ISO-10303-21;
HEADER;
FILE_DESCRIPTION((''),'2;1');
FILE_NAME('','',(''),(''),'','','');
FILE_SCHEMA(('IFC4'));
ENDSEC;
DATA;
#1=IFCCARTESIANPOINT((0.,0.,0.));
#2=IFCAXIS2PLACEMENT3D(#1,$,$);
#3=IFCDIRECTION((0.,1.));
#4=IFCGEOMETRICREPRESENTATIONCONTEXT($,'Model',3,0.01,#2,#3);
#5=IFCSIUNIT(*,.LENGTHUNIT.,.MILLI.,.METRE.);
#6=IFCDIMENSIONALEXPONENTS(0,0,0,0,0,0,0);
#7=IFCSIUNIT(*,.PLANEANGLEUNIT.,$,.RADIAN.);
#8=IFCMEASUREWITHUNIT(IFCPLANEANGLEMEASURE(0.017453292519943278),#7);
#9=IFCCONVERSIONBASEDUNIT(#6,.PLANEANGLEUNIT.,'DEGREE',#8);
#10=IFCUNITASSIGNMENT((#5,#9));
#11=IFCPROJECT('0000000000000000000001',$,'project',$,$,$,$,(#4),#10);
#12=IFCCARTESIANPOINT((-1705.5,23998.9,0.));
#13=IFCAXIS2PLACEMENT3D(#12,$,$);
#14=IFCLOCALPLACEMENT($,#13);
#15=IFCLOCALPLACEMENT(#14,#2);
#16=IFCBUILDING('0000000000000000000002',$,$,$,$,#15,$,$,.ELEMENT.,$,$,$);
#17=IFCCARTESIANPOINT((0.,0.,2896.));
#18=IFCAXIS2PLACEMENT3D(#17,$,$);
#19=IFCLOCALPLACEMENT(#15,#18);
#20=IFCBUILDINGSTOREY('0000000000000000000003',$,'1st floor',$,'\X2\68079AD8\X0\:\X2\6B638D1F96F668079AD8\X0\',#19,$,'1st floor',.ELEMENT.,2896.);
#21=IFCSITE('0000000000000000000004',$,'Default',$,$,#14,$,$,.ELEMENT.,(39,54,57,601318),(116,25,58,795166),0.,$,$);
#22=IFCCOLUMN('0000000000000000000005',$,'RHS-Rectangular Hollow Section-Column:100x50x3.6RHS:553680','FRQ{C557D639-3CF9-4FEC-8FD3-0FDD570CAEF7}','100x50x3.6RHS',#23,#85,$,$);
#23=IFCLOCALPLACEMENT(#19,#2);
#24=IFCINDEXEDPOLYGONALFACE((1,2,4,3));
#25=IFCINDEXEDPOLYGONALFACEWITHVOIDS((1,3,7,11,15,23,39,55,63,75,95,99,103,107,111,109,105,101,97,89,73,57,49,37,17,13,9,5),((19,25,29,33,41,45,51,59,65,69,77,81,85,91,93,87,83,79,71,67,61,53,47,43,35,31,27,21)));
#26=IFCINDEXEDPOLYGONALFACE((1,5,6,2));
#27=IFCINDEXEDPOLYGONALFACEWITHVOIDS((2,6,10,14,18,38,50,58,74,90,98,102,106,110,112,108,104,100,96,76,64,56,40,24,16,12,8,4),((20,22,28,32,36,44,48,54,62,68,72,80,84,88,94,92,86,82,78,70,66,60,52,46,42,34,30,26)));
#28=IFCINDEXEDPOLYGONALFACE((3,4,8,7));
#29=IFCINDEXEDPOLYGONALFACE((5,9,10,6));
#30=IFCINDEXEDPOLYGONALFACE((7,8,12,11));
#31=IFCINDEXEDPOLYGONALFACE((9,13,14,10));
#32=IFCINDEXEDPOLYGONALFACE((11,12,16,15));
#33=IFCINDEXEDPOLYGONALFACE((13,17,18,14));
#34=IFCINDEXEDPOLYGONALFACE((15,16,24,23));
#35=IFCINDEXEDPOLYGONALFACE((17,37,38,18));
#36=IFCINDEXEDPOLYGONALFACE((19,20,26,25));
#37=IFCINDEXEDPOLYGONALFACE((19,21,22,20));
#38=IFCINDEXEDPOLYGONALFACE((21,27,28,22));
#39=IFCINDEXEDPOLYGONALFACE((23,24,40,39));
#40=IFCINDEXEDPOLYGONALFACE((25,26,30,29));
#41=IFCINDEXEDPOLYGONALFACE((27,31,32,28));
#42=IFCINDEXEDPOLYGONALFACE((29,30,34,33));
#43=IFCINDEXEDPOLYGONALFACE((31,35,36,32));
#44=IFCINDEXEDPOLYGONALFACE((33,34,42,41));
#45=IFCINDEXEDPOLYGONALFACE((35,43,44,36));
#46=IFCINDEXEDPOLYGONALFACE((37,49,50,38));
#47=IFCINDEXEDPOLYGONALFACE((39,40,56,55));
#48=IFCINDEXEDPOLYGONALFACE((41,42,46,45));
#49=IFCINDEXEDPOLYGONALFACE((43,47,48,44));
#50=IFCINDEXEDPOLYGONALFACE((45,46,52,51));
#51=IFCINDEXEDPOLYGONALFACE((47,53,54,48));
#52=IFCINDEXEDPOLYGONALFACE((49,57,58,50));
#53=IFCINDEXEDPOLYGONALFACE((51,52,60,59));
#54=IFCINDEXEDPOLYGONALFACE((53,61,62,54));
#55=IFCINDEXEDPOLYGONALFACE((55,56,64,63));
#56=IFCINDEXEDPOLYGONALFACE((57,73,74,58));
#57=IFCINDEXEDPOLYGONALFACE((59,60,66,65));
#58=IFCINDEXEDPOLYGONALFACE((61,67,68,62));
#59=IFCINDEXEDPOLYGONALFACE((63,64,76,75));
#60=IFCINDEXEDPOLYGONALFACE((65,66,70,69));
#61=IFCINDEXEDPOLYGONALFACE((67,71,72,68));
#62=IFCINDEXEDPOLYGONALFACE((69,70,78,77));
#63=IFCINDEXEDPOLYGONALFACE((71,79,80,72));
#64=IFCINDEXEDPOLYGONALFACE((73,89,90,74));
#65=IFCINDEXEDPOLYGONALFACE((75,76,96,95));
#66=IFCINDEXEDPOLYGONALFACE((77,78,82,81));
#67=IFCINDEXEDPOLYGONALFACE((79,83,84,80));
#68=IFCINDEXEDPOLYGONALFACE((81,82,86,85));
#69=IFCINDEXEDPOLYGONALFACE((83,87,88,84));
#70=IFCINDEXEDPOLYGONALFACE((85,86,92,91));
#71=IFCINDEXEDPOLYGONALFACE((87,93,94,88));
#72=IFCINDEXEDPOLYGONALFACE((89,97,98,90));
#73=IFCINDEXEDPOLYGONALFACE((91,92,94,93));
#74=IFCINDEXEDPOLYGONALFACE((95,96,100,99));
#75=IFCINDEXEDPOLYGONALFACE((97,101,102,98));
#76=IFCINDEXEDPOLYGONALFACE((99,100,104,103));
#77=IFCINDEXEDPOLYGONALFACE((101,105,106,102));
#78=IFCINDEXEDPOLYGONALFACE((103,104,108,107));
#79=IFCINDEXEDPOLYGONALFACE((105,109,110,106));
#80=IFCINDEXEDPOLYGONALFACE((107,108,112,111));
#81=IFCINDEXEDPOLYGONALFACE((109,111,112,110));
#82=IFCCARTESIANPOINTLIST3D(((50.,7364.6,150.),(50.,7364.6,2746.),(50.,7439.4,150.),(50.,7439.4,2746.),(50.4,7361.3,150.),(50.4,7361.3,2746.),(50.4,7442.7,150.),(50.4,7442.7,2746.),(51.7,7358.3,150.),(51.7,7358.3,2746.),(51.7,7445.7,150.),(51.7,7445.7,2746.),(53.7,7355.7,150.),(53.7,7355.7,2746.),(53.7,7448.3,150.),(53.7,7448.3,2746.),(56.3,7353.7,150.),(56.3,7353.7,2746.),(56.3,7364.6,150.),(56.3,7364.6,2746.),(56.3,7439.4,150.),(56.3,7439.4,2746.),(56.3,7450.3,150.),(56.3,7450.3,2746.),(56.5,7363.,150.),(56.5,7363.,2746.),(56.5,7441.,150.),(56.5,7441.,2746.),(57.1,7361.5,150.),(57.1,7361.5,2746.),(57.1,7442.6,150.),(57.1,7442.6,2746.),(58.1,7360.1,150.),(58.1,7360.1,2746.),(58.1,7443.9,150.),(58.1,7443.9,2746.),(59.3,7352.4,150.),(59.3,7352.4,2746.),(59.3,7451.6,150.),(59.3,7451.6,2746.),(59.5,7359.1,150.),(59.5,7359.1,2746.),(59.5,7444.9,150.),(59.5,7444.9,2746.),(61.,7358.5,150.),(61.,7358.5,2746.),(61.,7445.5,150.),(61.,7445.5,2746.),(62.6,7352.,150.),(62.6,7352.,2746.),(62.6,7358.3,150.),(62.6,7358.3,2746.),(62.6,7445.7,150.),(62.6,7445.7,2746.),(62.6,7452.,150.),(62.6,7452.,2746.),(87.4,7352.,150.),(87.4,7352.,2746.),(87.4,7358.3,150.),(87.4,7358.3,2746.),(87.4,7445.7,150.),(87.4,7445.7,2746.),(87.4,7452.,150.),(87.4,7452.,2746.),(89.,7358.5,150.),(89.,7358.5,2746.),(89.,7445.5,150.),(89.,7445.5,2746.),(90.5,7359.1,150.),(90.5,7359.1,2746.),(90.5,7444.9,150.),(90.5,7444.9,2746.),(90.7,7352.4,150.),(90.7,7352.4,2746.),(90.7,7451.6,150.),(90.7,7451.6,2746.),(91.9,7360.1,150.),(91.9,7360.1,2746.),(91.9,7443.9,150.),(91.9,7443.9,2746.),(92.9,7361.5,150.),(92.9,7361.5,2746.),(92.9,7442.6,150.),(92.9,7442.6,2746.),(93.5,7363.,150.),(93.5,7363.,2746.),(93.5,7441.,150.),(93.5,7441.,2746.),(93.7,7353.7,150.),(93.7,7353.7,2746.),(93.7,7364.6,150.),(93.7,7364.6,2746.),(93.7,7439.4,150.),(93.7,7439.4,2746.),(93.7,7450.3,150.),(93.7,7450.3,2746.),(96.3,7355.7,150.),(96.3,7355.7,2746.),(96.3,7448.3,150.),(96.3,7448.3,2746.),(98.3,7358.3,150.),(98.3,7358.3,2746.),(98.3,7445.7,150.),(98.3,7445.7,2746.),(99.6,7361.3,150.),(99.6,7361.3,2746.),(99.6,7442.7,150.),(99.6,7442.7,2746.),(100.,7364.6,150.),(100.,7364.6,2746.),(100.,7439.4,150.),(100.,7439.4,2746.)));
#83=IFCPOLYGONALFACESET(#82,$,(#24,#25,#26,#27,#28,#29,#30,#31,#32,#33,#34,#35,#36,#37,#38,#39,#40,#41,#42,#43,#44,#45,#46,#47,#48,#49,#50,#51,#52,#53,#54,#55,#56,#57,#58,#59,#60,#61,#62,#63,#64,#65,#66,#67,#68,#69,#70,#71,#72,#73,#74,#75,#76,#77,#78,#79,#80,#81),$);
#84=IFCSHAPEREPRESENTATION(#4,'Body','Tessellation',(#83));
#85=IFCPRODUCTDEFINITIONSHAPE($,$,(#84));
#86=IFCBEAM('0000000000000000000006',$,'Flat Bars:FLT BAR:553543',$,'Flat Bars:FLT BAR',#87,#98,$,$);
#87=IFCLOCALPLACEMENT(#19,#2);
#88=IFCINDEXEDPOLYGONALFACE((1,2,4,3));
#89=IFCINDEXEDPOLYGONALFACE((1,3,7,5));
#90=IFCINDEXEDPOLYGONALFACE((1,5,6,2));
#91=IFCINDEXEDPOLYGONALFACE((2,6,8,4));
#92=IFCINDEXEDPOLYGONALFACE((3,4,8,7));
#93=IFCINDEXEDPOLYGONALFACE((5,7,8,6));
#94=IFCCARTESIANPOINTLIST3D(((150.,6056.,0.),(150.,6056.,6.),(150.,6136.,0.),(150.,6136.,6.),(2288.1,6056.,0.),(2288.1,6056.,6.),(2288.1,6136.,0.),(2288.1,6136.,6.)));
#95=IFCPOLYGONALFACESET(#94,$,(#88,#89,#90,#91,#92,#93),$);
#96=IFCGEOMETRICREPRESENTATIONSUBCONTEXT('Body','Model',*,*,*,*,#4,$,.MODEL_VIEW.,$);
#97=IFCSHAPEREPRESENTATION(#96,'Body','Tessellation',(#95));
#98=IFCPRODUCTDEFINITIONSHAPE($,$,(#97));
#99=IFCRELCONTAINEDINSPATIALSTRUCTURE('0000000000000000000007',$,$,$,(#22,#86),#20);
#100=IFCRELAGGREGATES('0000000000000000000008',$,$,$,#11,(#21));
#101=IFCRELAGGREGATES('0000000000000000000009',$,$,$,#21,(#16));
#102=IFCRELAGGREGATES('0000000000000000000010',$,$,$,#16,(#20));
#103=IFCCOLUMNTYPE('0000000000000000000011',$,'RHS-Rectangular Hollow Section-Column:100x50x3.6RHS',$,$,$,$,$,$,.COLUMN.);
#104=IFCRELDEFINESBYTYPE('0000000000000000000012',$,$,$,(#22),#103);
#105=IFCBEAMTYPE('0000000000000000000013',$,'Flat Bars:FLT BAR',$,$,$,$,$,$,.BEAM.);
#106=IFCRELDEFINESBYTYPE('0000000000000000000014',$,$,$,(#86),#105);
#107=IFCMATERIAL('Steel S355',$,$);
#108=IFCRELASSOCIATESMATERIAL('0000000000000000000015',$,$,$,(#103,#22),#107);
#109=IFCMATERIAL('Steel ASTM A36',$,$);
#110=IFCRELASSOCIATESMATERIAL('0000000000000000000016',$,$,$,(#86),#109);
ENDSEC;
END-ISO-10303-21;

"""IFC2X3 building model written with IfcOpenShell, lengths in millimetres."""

from ifc_helpers import new_model, entity, si_unit, converted_unit, direction, frame, origin, origin_2d, origin_2d_with_axis, place, context, subcontext, project, spatial, rectangle, hollow_rectangle, extrude, clip, halfspace, material, type_object, element, save


model = new_model("IFC2X3")

# Units and contexts
model_context = context("Model", 3, precision=0.01, world=origin(), true_north=direction((0.0, 1.0)))
body_context = subcontext(model_context, "Body", "Model", "MODEL_VIEW")
ifc_project = project(units=[si_unit("LENGTHUNIT", "METRE", prefix="MILLI"), converted_unit("PLANEANGLEUNIT", "DEGREE", entity("IfcPlaneAngleMeasure", 0.017453292519943278), si_unit("PLANEANGLEUNIT", "RADIAN"), dimensions=[0, 0, 0, 0, 0, 0, 0])], contexts=[model_context])

# Site, building, storey
site_placement = place(None, frame((-1705.5, 23998.9, 0.0)))
site = spatial("IfcSite", under=ifc_project, at=site_placement, Name="Default", CompositionType="ELEMENT", RefLatitude=(39, 54, 57, 601318), RefLongitude=(116, 25, 58, 795166), RefElevation=0.0)
building_placement = place(site_placement, origin())
building = spatial("IfcBuilding", under=site, at=building_placement, CompositionType="ELEMENT")
storey_placement = place(building_placement, frame((0.0, 0.0, 2896.0)))
storey = spatial("IfcBuildingStorey", under=building, at=storey_placement, Name="1st floor", ObjectType="标高:正负零标高", LongName="1st floor", CompositionType="ELEMENT", Elevation=2896.0)

# Column
ifc_material_1 = material(Name="Steel S355")
column_type = type_object("IfcColumnType", Name="RHS-Rectangular Hollow Section-Column:100x50x3.6RHS", PredefinedType="COLUMN", material=ifc_material_1)
column_1_placement = place(storey_placement, frame((75.0, 7402.0, 2746.0), z_axis=(0.0, 0.0, 1.0), x_axis=(-1.0, 0.0, 0.0)))
element("IfcColumn", 1, at=column_1_placement, inside=storey, type_object=column_type, material=ifc_material_1, Name="RHS-Rectangular Hollow Section-Column:100x50x3.6RHS:553680", Description="FRQ{C557D639-3CF9-4FEC-8FD3-0FDD570CAEF7}", ObjectType="100x50x3.6RHS", context=model_context, shape_type="Clipping", body=[
    clip(extrude(hollow_rectangle(XDim=50.0, YDim=100.0, WallThickness=6.3, InnerFilletRadius=6.3, OuterFilletRadius=12.6, at=origin_2d()), origin(), (0.0, 0.0, -1.0), 2651.9), halfspace(frame((75.0, 7402.0, -2596.0), z_axis=(0.0, 0.0, 1.0), x_axis=(-1.0, 0.0, 0.0)), True)),
])

# Beam
ifc_material_2 = material(Name="Steel ASTM A36")
beam_type = type_object("IfcBeamType", Name="Flat Bars:FLT BAR", PredefinedType="BEAM")
beam_placement = place(storey_placement, frame((150.0, 6096.0, 6.0)))
element("IfcBeam", 2, at=beam_placement, inside=storey, type_object=beam_type, material=ifc_material_2, Name="Flat Bars:FLT BAR:553543", ObjectType="Flat Bars:FLT BAR", context=body_context, shape_type="SweptSolid", body=[
    extrude(rectangle(XDim=6.0, YDim=80.0, at=origin_2d_with_axis()), frame((0.0, 0.0, -3.0), z_axis=(1.0, 0.0, 0.0), x_axis=(0.0, 0.0, -1.0)), (0.0, 0.0, 1.0), 2138.1),
])

save(model, "model.ifc")
